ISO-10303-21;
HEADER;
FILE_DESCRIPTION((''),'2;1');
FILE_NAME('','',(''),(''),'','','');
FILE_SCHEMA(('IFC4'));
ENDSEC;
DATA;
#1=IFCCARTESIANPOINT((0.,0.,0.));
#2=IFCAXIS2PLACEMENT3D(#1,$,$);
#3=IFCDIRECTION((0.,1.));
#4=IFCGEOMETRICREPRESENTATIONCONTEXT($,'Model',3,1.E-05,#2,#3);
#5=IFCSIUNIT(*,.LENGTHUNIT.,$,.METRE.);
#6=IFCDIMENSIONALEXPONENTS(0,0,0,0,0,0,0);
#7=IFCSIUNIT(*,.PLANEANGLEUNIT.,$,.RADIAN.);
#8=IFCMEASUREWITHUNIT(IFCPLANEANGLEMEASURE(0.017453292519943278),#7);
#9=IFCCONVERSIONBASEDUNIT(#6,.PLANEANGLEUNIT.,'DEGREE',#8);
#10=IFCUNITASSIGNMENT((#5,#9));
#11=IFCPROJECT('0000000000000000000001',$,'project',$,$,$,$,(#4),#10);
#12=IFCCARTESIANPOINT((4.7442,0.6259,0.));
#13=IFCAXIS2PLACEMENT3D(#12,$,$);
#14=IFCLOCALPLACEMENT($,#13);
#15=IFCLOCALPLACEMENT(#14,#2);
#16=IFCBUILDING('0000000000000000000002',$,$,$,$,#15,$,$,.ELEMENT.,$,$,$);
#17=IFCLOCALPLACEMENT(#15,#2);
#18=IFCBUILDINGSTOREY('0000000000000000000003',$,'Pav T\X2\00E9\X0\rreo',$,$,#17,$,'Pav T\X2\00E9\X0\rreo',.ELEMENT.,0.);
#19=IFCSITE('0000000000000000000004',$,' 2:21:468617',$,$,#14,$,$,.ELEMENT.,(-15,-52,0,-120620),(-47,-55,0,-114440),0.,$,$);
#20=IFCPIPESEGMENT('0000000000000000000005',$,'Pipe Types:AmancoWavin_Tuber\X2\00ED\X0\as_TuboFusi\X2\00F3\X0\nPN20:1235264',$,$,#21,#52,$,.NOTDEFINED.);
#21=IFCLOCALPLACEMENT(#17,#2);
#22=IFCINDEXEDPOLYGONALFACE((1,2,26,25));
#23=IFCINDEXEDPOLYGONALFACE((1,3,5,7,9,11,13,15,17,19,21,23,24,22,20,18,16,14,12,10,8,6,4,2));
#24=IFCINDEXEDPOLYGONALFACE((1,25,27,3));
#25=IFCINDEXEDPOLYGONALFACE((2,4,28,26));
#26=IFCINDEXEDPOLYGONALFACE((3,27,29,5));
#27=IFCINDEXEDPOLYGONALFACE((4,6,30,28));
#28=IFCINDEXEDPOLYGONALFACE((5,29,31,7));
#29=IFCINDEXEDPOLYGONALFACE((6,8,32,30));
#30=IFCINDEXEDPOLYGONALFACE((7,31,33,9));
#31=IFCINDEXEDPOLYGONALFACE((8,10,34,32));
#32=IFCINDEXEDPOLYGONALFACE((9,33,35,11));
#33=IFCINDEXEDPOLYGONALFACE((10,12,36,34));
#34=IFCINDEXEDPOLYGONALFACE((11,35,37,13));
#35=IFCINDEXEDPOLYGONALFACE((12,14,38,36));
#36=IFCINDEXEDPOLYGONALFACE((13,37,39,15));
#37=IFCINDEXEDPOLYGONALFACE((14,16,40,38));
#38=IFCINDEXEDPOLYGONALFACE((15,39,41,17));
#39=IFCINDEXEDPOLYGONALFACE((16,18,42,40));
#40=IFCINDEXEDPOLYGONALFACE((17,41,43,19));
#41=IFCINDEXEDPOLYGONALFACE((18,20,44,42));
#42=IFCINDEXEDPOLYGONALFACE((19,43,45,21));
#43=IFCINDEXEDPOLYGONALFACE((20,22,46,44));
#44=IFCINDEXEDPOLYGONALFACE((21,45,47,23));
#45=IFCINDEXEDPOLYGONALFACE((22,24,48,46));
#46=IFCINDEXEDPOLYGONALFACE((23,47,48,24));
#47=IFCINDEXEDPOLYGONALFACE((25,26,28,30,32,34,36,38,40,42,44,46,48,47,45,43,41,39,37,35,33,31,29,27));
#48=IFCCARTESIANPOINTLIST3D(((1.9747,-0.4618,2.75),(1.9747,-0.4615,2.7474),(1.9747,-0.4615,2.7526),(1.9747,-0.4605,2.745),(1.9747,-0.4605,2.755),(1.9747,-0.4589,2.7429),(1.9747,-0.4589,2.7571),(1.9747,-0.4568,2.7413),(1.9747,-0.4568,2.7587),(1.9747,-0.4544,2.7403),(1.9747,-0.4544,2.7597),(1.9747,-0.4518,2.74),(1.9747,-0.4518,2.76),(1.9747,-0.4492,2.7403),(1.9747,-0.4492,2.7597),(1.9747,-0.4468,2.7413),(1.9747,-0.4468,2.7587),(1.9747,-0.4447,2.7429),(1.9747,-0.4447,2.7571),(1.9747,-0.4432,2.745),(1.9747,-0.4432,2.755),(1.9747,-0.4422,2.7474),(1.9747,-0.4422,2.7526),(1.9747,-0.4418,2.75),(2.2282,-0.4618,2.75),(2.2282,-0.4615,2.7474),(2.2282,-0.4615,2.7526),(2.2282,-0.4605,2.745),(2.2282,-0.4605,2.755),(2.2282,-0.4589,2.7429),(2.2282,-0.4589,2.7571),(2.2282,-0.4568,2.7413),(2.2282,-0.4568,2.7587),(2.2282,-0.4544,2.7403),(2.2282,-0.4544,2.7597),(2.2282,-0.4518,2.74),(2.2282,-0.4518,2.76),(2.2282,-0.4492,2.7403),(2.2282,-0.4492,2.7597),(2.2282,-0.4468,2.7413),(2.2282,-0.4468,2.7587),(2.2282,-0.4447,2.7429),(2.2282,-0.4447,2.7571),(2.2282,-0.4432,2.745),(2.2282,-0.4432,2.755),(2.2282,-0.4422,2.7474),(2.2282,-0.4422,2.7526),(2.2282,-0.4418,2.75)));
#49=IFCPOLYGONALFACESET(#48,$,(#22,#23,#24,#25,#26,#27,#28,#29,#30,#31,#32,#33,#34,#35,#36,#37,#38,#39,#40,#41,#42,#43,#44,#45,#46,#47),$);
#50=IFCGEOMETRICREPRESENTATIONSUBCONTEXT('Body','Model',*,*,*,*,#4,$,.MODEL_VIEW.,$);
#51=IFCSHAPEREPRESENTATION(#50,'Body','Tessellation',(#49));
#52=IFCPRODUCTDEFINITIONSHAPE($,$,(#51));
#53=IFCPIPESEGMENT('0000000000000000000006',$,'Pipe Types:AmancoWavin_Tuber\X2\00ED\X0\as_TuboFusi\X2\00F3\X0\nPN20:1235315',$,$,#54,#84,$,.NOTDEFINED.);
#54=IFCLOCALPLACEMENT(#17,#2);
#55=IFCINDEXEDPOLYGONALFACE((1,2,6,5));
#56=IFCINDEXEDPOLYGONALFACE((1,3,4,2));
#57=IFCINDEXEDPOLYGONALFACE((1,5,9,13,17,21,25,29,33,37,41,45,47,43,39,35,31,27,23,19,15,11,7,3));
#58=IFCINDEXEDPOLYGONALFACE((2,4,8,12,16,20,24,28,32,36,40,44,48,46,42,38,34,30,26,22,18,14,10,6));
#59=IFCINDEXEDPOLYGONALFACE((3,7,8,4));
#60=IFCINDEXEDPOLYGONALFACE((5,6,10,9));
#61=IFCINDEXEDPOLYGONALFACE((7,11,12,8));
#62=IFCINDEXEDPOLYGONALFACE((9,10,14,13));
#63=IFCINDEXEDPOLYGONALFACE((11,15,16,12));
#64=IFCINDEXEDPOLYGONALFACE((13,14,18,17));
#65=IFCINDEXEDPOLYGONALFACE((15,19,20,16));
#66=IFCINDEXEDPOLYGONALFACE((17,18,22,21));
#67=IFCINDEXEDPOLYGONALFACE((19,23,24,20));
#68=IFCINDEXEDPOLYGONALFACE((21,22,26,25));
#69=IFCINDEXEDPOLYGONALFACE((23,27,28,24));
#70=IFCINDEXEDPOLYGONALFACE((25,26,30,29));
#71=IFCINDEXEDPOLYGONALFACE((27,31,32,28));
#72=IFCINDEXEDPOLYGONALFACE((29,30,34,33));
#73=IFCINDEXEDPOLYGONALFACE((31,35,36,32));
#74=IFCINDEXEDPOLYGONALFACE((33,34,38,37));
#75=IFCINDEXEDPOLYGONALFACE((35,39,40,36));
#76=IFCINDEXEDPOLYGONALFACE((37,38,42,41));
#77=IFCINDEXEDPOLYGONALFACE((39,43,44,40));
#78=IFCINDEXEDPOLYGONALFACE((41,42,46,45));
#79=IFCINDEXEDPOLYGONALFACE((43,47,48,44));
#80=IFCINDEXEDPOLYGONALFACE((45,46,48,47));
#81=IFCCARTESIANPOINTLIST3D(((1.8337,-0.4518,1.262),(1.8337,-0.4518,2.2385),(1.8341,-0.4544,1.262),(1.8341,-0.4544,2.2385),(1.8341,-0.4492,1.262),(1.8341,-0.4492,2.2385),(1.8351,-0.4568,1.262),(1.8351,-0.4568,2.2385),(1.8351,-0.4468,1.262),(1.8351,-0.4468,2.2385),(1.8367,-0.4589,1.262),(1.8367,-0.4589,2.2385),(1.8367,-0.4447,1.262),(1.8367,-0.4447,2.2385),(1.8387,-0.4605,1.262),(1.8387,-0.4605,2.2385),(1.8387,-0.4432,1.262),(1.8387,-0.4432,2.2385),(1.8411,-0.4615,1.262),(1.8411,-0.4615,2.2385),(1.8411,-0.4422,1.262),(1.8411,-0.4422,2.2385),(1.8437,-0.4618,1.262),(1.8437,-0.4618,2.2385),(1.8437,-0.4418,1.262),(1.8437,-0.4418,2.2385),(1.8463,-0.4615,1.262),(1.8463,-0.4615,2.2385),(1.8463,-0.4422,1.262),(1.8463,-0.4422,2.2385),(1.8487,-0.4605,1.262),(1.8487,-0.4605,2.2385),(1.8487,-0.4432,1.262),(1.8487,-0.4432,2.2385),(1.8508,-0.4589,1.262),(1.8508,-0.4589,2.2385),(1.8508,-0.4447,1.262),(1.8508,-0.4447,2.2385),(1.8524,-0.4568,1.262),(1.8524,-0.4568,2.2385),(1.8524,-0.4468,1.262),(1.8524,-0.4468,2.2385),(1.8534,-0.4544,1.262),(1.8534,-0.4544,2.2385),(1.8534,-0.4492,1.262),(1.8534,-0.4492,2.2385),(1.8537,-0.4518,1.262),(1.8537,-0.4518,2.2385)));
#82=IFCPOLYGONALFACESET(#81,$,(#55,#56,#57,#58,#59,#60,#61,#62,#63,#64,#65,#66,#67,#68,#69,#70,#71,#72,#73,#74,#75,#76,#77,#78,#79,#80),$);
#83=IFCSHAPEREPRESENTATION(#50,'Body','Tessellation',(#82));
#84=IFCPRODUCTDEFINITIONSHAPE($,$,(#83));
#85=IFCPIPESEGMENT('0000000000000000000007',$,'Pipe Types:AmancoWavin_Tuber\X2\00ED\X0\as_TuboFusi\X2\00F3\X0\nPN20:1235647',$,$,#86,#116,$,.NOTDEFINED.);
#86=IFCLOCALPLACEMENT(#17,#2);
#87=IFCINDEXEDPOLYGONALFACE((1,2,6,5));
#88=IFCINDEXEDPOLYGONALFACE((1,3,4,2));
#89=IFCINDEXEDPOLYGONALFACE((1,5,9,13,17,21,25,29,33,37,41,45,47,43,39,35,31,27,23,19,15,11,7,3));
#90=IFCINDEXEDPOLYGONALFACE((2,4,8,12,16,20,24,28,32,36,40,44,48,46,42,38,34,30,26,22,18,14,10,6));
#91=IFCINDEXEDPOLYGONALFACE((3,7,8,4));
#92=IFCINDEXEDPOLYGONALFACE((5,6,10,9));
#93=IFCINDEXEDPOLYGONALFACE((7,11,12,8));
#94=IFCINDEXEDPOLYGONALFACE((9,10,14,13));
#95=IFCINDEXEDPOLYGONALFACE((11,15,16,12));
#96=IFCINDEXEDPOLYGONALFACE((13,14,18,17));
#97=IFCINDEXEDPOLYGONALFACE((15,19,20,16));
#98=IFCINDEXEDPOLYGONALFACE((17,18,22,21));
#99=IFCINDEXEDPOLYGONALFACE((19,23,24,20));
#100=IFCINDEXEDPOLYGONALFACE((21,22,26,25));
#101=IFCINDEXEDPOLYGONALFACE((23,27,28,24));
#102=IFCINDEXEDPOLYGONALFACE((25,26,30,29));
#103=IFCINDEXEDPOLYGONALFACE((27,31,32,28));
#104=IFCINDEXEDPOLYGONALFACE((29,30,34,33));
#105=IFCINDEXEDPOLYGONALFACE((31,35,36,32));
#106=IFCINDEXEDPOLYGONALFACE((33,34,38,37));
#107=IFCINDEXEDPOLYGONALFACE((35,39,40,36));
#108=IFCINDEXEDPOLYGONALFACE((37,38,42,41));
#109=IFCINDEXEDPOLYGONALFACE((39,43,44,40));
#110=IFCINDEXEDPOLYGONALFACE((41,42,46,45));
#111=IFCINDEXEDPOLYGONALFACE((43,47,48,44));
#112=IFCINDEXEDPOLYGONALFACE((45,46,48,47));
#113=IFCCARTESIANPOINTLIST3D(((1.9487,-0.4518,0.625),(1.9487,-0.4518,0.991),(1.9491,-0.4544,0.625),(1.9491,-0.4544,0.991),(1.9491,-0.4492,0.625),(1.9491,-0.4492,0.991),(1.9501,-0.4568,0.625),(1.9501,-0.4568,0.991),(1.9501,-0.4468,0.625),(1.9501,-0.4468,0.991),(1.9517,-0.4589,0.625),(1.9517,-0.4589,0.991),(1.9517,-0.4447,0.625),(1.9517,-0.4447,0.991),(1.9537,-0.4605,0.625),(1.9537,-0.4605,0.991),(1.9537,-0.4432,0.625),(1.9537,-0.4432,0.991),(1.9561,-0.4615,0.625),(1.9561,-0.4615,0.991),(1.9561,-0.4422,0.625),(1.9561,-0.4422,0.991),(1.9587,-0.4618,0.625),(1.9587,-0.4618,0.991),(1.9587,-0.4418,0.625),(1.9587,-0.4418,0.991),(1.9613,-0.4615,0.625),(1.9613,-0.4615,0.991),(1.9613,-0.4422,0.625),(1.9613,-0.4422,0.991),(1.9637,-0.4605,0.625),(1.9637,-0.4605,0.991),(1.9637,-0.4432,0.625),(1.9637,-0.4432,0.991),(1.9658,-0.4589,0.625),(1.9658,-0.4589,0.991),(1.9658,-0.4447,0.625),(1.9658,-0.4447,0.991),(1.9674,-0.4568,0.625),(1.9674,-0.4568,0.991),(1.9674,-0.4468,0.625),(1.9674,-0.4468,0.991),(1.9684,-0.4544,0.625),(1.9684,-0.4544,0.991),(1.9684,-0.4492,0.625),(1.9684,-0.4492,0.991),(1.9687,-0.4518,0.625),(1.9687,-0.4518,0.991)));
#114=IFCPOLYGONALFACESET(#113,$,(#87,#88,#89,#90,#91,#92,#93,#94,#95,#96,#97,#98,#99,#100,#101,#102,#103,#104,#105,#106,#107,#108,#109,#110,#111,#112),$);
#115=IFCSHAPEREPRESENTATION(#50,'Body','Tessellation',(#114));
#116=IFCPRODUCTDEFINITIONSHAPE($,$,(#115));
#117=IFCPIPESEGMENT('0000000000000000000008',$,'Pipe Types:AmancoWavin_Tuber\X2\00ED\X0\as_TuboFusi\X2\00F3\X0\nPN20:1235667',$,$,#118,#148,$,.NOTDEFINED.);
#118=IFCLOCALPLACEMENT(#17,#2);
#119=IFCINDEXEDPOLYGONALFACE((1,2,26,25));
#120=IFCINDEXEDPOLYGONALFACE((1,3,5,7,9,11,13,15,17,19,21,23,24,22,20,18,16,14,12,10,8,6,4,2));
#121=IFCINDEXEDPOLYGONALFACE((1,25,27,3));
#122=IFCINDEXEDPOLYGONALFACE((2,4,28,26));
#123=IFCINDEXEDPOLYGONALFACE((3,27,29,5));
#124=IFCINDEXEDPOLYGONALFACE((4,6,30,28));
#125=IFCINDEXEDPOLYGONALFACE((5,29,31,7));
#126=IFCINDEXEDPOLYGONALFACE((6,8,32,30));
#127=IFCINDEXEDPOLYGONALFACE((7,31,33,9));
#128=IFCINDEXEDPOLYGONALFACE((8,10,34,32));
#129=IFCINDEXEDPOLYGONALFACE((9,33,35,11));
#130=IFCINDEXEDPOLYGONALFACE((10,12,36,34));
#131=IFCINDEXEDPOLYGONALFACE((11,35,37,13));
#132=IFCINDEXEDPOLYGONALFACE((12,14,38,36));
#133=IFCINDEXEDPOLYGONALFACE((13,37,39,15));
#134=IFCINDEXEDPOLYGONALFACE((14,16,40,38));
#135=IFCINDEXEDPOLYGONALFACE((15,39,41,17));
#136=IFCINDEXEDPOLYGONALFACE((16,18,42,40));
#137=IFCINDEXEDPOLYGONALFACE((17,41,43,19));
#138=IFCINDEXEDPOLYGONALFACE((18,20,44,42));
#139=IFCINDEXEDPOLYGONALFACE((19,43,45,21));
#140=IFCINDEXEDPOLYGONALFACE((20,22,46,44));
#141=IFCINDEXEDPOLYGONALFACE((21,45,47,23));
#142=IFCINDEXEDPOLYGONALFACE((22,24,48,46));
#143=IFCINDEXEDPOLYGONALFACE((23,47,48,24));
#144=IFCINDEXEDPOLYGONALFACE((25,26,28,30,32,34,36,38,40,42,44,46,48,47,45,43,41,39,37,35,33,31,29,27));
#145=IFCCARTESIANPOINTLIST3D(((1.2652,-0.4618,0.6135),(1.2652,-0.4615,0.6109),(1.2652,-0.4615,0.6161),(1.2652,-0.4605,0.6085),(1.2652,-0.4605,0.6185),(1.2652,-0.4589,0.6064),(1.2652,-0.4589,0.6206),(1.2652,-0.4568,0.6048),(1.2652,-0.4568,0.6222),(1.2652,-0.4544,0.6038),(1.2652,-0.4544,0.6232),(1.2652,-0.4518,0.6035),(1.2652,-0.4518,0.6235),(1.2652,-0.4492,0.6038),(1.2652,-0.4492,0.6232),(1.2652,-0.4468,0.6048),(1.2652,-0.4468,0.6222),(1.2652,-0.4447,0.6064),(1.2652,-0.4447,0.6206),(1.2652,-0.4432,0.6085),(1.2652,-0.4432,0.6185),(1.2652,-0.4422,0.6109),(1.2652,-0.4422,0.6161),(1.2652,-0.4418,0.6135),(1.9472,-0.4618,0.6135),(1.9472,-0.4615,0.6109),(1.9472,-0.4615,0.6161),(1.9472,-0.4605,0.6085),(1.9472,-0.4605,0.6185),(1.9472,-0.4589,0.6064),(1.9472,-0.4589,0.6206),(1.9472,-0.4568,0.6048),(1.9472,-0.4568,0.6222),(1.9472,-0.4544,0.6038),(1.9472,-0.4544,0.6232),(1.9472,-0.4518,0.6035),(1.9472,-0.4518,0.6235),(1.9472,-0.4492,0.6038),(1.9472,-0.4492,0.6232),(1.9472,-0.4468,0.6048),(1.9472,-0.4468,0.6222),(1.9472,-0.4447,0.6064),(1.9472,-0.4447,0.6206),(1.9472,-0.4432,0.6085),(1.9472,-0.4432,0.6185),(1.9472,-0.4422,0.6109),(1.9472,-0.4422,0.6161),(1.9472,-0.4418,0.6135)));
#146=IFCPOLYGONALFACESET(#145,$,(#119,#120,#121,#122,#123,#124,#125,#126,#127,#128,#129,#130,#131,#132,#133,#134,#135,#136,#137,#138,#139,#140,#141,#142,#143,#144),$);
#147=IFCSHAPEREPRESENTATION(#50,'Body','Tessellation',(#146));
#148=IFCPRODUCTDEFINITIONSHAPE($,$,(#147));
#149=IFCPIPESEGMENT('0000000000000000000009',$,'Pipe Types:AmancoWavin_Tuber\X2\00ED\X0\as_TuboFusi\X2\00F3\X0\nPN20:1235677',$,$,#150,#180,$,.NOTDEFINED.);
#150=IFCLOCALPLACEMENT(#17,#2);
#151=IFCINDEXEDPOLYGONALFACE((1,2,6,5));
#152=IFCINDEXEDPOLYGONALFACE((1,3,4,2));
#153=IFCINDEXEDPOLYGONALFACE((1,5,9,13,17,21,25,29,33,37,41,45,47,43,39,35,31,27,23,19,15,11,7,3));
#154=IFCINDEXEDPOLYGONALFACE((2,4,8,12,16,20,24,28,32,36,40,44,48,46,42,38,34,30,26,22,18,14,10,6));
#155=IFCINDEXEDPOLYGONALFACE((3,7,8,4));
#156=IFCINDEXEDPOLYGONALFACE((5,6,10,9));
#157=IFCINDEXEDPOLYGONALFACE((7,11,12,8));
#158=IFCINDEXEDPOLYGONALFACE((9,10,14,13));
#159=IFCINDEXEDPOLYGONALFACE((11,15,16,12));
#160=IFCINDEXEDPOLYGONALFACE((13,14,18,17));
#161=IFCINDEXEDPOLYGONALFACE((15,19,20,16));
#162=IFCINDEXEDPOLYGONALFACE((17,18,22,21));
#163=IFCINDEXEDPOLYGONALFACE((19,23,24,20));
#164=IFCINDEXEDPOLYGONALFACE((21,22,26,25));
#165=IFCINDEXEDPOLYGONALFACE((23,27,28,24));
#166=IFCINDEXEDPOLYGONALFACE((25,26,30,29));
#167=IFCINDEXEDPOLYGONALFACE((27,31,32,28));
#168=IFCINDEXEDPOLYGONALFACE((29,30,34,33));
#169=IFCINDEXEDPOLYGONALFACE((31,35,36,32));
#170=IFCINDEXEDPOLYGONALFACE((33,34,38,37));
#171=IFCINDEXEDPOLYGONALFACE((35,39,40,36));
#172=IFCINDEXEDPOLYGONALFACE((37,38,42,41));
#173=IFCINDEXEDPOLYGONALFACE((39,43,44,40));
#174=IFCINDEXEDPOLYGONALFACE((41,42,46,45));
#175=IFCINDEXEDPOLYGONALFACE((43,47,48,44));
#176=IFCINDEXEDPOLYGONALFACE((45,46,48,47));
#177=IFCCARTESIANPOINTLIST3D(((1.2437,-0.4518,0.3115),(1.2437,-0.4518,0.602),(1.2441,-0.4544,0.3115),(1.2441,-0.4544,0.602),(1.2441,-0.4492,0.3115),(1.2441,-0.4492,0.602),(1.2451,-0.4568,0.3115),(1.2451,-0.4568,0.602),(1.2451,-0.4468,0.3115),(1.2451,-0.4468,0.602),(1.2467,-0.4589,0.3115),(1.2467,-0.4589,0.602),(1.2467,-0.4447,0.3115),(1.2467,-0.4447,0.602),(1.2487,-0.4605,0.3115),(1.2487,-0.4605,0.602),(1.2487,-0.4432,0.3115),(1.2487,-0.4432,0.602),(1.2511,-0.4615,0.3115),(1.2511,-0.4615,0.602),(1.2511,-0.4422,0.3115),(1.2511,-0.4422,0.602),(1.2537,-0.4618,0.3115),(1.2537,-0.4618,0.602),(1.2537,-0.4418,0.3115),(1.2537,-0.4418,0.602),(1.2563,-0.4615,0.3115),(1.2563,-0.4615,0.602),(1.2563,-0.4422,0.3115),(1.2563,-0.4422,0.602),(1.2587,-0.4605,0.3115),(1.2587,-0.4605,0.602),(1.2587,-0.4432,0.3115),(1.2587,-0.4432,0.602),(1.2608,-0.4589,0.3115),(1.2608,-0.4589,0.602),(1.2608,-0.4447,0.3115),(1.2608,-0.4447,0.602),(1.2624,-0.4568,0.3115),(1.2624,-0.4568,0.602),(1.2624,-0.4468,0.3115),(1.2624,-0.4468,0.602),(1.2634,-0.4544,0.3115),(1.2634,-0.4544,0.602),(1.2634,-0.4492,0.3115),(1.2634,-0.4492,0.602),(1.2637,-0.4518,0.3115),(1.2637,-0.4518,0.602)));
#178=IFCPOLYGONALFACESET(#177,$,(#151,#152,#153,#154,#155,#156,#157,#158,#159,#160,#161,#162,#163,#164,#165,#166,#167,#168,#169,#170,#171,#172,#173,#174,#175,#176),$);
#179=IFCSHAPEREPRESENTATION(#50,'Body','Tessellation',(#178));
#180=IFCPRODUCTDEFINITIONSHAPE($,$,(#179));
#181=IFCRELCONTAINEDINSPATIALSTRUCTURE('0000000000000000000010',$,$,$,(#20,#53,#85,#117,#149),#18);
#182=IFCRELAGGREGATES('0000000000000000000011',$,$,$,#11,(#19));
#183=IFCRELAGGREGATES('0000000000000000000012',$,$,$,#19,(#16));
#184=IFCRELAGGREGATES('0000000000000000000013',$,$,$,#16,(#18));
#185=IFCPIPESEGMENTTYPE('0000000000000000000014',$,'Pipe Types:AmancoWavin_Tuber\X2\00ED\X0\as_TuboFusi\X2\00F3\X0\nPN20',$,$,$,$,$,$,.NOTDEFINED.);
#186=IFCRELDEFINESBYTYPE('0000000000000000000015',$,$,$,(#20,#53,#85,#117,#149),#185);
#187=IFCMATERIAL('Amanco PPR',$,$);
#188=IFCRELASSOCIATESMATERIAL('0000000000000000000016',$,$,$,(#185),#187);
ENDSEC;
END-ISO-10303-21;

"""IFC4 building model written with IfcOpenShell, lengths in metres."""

from ifc_helpers import new_model, entity, si_unit, converted_unit, direction, frame, origin, place, context, subcontext, project, spatial, arc, indexed_curve, outline, extrude, material, type_object, element, save


model = new_model("IFC4")

# Units and contexts
model_context = context("Model", 3, precision=1e-05, world=origin(), true_north=direction((0.0, 1.0)))
body_context = subcontext(model_context, "Body", "Model", "MODEL_VIEW")
ifc_project = project(units=[si_unit("LENGTHUNIT", "METRE"), converted_unit("PLANEANGLEUNIT", "DEGREE", entity("IfcPlaneAngleMeasure", 0.017453292519943278), si_unit("PLANEANGLEUNIT", "RADIAN"), dimensions=[0, 0, 0, 0, 0, 0, 0])], contexts=[model_context])

# Site, building, storey
site_placement = place(None, frame((4.7442, 0.6259, 0.0)))
site = spatial("IfcSite", under=ifc_project, at=site_placement, Name=" 2:21:468617", CompositionType="ELEMENT", RefLatitude=(-15, -52, 0, -120620), RefLongitude=(-47, -55, 0, -114440), RefElevation=0.0)
building_placement = place(site_placement, origin())
building = spatial("IfcBuilding", under=site, at=building_placement, CompositionType="ELEMENT")
storey_placement = place(building_placement, origin())
storey = spatial("IfcBuildingStorey", under=building, at=storey_placement, Name="Pav Térreo", LongName="Pav Térreo", CompositionType="ELEMENT", Elevation=0.0)

# Pipe segments
ifc_material_1 = material(Name="Amanco PPR")
pipe_segment_type_1 = type_object("IfcPipeSegmentType", Name="Pipe Types:AmancoWavin_Tuberías_TuboFusiónPN20", PredefinedType="NOTDEFINED", material=ifc_material_1)
pipe_segment_1_placement = place(storey_placement, origin())
element("IfcPipeSegment", 1, at=pipe_segment_1_placement, inside=storey, type_object=pipe_segment_type_1, Name="Pipe Types:AmancoWavin_Tuberías_TuboFusiónPN20:1235264", PredefinedType="NOTDEFINED", context=body_context, shape_type="SweptSolid", body=[
    extrude(outline(indexed_curve([(0.01, 0.0), (0.0071, 0.0071), (0.0, 0.01), (-0.0071, 0.0071), (-0.01, 0.0), (-0.0071, -0.0071), (0.0, -0.01), (0.0071, -0.0071)], segments=[arc(1, 2, 3), arc(3, 4, 5), arc(5, 6, 7), arc(7, 8, 1)], self_intersect=False)), frame((1.9747, -0.4518, 2.75), z_axis=(1.0, 0.0, 0.0), x_axis=(0.0, -1.0, 0.0)), (0.0, 0.0, 1.0), 0.2535),
])
pipe_segment_2_placement = place(storey_placement, origin())
element("IfcPipeSegment", 2, at=pipe_segment_2_placement, inside=storey, type_object=pipe_segment_type_1, Name="Pipe Types:AmancoWavin_Tuberías_TuboFusiónPN20:1235315", PredefinedType="NOTDEFINED", context=body_context, shape_type="SweptSolid", body=[
    extrude(outline(indexed_curve([(0.01, 0.0), (0.0071, 0.0071), (0.0, 0.01), (-0.0071, 0.0071), (-0.01, 0.0), (-0.0071, -0.0071), (0.0, -0.01), (0.0071, -0.0071)], segments=[arc(1, 2, 3), arc(3, 4, 5), arc(5, 6, 7), arc(7, 8, 1)], self_intersect=False)), frame((1.8437, -0.4518, 1.262), z_axis=(0.0, 0.0, 1.0), x_axis=(-1.0, 0.0, 0.0)), (0.0, 0.0, 1.0), 0.9765),
])
pipe_segment_3_placement = place(storey_placement, origin())
element("IfcPipeSegment", 3, at=pipe_segment_3_placement, inside=storey, type_object=pipe_segment_type_1, Name="Pipe Types:AmancoWavin_Tuberías_TuboFusiónPN20:1235647", PredefinedType="NOTDEFINED", context=body_context, shape_type="SweptSolid", body=[
    extrude(outline(indexed_curve([(0.01, 0.0), (0.0071, 0.0071), (0.0, 0.01), (-0.0071, 0.0071), (-0.01, 0.0), (-0.0071, -0.0071), (0.0, -0.01), (0.0071, -0.0071)], segments=[arc(1, 2, 3), arc(3, 4, 5), arc(5, 6, 7), arc(7, 8, 1)], self_intersect=False)), frame((1.9587, -0.4518, 0.625)), (0.0, 0.0, 1.0), 0.366),
])
pipe_segment_4_placement = place(storey_placement, origin())
element("IfcPipeSegment", 4, at=pipe_segment_4_placement, inside=storey, type_object=pipe_segment_type_1, Name="Pipe Types:AmancoWavin_Tuberías_TuboFusiónPN20:1235667", PredefinedType="NOTDEFINED", context=body_context, shape_type="SweptSolid", body=[
    extrude(outline(indexed_curve([(0.01, 0.0), (0.0071, 0.0071), (0.0, 0.01), (-0.0071, 0.0071), (-0.01, 0.0), (-0.0071, -0.0071), (0.0, -0.01), (0.0071, -0.0071)], segments=[arc(1, 2, 3), arc(3, 4, 5), arc(5, 6, 7), arc(7, 8, 1)], self_intersect=False)), frame((1.2652, -0.4518, 0.6135), z_axis=(1.0, 0.0, 0.0), x_axis=(0.0, 1.0, 0.0)), (0.0, 0.0, 1.0), 0.682),
])
pipe_segment_5_placement = place(storey_placement, origin())
element("IfcPipeSegment", 5, at=pipe_segment_5_placement, inside=storey, type_object=pipe_segment_type_1, Name="Pipe Types:AmancoWavin_Tuberías_TuboFusiónPN20:1235677", PredefinedType="NOTDEFINED", context=body_context, shape_type="SweptSolid", body=[
    extrude(outline(indexed_curve([(0.01, 0.0), (0.0071, 0.0071), (0.0, 0.01), (-0.0071, 0.0071), (-0.01, 0.0), (-0.0071, -0.0071), (0.0, -0.01), (0.0071, -0.0071)], segments=[arc(1, 2, 3), arc(3, 4, 5), arc(5, 6, 7), arc(7, 8, 1)], self_intersect=False)), frame((1.2537, -0.4518, 0.3115)), (0.0, 0.0, 1.0), 0.2905),
])

save(model, "model.ifc")
